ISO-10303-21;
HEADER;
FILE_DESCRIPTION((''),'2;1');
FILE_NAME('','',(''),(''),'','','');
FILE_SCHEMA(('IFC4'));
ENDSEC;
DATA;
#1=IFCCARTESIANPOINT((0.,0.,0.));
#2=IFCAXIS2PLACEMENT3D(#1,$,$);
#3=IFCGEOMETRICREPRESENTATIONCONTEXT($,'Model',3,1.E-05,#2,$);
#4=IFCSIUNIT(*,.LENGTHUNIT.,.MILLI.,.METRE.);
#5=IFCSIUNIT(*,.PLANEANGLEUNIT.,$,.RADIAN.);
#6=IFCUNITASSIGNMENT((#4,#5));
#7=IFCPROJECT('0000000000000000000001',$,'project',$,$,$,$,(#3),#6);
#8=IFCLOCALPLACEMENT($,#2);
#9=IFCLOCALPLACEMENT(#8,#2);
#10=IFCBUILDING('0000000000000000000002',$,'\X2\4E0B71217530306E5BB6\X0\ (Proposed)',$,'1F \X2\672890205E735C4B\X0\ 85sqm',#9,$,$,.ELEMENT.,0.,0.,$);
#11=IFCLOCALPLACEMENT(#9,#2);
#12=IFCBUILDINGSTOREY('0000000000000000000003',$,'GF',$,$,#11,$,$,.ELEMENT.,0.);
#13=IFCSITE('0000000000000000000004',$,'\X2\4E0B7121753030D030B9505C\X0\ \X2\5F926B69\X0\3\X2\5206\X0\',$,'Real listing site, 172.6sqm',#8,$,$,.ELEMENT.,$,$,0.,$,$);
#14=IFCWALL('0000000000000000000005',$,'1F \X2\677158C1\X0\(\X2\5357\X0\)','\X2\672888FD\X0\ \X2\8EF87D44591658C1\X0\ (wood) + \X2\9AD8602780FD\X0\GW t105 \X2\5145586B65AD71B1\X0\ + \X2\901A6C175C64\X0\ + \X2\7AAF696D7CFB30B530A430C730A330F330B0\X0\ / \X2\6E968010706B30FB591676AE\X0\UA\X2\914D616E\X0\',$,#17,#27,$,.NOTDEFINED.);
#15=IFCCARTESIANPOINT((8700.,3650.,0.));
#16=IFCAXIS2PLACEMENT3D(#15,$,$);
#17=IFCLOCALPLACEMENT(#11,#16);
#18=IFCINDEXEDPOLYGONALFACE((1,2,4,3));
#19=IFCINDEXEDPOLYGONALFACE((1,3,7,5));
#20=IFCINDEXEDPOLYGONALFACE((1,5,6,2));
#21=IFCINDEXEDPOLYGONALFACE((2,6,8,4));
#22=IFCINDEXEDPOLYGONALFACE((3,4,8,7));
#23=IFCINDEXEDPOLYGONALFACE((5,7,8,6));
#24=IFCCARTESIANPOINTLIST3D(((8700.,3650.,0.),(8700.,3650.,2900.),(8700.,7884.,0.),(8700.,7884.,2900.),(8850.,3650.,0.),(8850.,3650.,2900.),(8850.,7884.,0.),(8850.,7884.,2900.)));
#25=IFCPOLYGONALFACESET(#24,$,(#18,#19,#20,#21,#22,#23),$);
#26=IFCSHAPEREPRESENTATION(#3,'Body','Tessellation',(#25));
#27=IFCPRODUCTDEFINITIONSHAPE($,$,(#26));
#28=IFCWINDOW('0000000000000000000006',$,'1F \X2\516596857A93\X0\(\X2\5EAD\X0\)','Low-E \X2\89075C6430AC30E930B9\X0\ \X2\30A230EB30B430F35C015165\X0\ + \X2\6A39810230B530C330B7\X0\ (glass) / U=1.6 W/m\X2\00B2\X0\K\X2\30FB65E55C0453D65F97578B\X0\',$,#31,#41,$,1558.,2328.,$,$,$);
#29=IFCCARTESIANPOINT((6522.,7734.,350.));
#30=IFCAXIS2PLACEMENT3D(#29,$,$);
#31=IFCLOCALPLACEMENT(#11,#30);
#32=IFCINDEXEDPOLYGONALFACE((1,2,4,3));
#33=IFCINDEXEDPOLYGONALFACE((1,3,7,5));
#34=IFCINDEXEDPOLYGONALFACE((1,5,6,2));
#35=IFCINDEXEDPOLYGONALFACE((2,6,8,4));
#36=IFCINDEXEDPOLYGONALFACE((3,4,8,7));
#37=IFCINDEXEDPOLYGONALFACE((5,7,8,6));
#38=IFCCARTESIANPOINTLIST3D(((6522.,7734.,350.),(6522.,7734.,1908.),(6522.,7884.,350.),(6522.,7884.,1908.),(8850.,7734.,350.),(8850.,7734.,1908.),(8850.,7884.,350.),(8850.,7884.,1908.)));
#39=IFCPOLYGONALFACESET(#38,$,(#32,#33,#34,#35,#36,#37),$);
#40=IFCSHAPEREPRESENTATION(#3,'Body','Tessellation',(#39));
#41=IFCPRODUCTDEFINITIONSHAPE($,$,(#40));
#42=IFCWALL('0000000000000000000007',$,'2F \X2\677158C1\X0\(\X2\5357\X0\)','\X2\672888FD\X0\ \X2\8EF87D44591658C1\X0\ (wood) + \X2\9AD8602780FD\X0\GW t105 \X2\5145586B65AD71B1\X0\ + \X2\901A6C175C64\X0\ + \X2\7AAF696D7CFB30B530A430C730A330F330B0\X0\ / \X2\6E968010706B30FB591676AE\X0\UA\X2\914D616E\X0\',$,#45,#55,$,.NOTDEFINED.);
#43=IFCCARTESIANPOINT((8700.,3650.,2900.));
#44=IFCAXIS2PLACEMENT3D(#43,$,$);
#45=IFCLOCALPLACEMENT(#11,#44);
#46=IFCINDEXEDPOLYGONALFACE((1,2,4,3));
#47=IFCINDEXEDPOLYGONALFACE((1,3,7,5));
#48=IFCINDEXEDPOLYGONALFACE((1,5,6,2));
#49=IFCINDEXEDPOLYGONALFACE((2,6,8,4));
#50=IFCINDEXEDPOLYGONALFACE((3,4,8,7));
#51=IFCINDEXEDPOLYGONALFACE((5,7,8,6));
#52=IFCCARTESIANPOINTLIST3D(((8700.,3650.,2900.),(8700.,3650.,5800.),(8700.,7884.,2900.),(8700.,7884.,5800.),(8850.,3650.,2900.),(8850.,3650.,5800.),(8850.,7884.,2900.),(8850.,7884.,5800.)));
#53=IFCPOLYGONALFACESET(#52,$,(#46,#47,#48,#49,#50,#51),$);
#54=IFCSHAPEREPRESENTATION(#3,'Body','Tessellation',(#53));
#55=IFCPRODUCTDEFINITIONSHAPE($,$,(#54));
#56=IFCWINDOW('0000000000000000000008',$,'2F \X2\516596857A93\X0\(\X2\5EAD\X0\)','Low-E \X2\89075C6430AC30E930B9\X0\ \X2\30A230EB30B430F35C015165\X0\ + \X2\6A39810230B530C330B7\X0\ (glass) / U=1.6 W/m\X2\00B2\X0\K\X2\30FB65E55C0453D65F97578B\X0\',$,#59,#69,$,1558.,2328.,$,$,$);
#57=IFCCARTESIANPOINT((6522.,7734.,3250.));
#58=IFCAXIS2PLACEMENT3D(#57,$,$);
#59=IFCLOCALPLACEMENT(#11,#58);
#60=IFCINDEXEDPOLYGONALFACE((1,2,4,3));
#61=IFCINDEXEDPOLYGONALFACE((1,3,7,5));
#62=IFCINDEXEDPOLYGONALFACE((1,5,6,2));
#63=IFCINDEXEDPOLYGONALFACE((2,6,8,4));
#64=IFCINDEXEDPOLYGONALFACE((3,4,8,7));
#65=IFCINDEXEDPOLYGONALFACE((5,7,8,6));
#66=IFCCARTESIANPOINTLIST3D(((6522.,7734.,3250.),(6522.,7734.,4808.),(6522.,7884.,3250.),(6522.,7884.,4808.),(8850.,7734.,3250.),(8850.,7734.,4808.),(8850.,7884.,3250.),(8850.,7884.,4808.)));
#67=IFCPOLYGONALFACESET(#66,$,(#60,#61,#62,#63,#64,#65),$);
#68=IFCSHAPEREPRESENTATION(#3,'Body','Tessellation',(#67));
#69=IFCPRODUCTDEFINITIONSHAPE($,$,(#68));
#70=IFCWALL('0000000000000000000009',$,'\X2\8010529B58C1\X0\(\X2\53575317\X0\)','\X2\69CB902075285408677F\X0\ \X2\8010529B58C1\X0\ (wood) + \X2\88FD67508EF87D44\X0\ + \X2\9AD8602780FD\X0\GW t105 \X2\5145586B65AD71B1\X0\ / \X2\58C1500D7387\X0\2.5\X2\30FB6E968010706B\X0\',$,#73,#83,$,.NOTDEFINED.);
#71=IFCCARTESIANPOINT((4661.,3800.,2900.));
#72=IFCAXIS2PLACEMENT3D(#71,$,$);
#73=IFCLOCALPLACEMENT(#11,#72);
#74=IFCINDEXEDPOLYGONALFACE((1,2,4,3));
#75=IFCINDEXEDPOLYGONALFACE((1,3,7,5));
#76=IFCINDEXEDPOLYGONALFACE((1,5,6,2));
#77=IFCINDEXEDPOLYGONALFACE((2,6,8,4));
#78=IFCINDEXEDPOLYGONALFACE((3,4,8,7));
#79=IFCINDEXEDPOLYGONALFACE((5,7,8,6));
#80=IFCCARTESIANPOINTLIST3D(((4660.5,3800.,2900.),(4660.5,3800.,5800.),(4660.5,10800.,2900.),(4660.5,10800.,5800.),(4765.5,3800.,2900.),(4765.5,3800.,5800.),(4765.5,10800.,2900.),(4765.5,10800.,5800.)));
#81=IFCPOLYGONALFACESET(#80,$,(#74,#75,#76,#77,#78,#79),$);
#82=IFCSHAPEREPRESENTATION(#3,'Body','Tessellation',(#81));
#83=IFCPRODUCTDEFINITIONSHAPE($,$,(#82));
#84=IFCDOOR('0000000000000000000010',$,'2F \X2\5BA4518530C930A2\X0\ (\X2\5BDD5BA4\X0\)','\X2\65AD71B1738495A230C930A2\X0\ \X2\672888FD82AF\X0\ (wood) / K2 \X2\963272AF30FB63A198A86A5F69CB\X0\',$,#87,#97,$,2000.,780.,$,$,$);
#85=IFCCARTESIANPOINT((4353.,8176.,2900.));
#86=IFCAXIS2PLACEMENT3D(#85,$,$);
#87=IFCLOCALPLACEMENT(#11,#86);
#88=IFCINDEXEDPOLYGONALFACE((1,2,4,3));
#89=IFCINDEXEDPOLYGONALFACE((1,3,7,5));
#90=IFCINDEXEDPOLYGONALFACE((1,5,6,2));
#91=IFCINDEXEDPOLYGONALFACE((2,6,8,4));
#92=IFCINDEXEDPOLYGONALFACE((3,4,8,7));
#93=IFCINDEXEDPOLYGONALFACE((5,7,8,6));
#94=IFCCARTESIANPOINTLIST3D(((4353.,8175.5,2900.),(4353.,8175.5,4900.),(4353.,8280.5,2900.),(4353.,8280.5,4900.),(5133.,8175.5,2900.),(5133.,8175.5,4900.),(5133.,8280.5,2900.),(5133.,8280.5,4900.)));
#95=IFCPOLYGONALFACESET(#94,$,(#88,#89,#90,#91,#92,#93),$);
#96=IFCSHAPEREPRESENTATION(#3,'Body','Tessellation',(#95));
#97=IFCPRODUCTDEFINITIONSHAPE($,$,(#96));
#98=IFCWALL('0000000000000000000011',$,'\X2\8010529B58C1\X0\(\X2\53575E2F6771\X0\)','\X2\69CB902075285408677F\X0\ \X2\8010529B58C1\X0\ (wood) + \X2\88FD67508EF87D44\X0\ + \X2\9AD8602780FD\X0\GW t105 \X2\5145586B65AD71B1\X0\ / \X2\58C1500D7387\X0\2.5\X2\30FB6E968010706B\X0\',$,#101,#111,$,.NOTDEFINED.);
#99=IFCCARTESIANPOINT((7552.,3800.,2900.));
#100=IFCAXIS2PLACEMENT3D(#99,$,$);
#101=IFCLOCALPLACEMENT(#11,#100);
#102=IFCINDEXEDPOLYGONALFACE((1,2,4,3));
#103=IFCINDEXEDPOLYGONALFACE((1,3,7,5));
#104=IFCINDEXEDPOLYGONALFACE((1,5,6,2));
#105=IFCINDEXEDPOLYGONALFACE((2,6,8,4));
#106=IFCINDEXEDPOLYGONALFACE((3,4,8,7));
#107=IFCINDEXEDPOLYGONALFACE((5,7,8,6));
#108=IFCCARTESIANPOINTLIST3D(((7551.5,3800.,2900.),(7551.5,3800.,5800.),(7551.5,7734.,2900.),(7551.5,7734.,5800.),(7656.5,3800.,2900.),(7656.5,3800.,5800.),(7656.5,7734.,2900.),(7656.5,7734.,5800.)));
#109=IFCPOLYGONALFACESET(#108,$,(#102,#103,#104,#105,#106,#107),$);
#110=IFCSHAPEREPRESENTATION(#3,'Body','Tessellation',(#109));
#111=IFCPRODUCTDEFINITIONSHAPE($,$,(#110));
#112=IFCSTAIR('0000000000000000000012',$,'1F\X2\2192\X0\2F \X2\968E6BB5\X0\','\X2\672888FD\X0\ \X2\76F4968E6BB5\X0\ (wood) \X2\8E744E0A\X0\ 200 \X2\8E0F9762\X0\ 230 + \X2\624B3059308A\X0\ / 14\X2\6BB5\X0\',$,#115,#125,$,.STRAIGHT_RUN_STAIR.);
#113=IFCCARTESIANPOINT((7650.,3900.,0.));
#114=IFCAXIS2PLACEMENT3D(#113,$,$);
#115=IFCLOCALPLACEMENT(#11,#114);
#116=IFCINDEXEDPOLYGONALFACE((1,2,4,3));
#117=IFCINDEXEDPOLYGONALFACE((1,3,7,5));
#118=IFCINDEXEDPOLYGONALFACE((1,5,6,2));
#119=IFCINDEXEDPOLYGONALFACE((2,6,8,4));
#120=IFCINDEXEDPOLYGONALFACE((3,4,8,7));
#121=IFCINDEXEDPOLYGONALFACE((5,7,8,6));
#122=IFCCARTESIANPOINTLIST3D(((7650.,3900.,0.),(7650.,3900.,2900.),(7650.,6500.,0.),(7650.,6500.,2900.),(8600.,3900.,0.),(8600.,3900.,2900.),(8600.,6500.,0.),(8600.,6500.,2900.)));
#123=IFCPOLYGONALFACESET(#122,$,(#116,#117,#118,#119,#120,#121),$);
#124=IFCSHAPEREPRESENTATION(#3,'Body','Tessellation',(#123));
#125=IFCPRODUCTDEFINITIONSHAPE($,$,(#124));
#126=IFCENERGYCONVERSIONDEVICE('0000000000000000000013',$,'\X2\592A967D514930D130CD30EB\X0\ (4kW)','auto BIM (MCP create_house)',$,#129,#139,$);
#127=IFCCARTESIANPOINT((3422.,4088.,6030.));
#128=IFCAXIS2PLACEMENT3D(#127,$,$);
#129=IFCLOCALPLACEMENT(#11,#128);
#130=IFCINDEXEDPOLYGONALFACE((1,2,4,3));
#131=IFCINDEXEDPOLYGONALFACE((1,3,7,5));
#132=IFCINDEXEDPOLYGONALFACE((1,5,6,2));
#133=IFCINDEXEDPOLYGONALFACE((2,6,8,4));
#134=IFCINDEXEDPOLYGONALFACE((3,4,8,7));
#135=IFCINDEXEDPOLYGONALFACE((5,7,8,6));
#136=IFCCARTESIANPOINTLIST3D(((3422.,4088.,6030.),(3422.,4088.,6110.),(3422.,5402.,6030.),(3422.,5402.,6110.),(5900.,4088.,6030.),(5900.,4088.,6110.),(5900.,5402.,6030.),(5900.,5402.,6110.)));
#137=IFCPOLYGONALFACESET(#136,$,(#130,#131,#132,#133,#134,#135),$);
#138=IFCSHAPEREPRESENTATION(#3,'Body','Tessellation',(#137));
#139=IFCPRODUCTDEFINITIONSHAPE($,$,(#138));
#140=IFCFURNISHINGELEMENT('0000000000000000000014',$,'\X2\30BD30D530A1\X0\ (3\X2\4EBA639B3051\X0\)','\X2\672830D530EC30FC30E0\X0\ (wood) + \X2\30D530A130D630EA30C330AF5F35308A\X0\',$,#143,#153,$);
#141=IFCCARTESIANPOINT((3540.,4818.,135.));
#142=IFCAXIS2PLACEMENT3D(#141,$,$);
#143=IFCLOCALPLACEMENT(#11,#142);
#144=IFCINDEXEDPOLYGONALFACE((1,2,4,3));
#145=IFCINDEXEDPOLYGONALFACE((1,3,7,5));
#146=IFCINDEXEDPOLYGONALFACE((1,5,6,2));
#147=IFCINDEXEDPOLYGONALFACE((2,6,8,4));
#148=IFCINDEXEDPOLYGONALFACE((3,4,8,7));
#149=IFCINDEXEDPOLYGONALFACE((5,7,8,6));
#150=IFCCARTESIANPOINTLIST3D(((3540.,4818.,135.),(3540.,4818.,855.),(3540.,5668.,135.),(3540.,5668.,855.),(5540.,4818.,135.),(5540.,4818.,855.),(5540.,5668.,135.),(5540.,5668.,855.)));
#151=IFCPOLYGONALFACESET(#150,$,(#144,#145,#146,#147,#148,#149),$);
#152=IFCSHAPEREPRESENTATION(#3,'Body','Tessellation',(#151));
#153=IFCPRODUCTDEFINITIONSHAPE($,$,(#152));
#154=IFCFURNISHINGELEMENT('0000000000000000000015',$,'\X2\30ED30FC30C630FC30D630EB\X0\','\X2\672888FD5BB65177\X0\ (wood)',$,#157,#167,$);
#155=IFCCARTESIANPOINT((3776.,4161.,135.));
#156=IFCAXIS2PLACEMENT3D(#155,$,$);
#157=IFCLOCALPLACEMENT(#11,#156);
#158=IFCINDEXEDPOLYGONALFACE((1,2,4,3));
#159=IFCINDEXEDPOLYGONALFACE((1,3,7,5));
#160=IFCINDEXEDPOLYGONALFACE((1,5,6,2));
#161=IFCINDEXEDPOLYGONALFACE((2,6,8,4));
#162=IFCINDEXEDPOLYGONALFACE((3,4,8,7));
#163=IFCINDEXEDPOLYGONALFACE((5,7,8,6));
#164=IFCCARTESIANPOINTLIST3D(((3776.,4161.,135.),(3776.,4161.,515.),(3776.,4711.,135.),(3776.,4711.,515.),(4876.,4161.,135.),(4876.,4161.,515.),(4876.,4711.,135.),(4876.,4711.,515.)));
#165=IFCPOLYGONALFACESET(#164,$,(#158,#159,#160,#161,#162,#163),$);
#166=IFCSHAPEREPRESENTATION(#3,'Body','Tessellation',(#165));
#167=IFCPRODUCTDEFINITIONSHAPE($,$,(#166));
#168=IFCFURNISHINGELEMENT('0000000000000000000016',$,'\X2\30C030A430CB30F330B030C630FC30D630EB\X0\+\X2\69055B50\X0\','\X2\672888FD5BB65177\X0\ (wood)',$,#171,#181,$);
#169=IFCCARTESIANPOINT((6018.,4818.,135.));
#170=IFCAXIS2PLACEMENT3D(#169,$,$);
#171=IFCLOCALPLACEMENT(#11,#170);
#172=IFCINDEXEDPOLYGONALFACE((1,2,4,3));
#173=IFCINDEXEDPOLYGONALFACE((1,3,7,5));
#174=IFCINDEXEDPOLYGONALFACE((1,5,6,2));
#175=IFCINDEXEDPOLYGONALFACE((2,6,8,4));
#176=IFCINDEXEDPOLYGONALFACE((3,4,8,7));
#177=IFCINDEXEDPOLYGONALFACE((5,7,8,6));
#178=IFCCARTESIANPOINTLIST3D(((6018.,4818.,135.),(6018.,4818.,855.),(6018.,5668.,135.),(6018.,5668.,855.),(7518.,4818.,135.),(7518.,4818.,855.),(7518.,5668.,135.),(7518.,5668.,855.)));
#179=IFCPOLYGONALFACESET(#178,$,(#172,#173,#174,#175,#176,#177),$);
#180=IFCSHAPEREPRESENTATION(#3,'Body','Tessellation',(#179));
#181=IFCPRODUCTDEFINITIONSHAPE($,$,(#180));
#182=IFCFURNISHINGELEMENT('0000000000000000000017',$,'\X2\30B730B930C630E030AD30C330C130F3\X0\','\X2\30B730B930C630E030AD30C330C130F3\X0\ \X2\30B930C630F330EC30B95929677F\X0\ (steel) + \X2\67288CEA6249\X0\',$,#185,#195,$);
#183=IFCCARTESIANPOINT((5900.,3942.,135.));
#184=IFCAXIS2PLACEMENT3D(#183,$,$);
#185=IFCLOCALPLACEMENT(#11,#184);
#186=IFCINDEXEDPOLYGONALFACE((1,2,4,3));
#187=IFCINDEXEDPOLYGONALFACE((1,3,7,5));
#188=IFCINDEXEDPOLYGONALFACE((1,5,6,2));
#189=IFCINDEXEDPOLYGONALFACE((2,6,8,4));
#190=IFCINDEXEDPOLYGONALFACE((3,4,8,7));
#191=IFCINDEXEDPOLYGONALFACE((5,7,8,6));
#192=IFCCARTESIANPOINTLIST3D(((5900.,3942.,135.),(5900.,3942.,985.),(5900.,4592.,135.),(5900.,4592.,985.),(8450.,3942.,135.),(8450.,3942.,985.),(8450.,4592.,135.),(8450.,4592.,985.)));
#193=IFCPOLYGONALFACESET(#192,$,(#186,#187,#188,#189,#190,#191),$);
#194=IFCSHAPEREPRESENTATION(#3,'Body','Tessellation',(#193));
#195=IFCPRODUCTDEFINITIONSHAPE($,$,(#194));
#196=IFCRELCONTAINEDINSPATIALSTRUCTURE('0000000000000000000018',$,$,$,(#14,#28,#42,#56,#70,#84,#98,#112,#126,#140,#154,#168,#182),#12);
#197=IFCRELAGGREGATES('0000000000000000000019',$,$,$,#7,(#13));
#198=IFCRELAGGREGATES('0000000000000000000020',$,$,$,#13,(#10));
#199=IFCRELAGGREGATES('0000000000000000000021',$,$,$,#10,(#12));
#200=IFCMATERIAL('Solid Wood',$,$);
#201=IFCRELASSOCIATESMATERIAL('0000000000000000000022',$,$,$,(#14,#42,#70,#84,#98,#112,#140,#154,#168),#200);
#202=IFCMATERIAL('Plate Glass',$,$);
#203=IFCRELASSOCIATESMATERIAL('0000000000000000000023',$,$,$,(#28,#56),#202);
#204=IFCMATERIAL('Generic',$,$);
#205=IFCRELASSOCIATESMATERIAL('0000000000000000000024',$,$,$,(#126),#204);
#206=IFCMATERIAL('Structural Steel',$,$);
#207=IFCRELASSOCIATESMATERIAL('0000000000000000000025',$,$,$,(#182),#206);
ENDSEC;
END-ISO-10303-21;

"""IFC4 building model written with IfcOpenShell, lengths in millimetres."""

from ifc_helpers import new_model, si_unit, frame, frame_2d, origin, place, context, project, spatial, rectangle, extrude, material, element, fill, save


model = new_model("IFC4")

# Units and contexts
model_context = context("Model", 3, precision=1e-05, world=origin())
ifc_project = project(units=[si_unit("LENGTHUNIT", "METRE", prefix="MILLI"), si_unit("PLANEANGLEUNIT", "RADIAN")], contexts=[model_context])

# Site, building, storey
site_placement = place(None, origin())
site = spatial("IfcSite", under=ifc_project, at=site_placement, Name="下無田バス停 徒歩3分", ObjectType="Real listing site, 172.6sqm", CompositionType="ELEMENT", RefElevation=0.0)
building_placement = place(site_placement, origin())
building = spatial("IfcBuilding", under=site, at=building_placement, Name="下無田の家 (Proposed)", ObjectType="1F 木造平屋 85sqm", CompositionType="ELEMENT", ElevationOfRefHeight=0.0, ElevationOfTerrain=0.0)
storey_placement = place(building_placement, origin())
storey = spatial("IfcBuildingStorey", under=building, at=storey_placement, Name="GF", CompositionType="ELEMENT", Elevation=0.0)

# Wall, opening, window
ifc_material_1 = material(Name="Solid Wood")
wall_1_placement = place(storey_placement, frame((8700.0, 3650.0, 0.0)))
wall_1 = element("IfcWall", 1, at=wall_1_placement, inside=storey, material=ifc_material_1, Name="1F 東壁(南)", Description="木製 軸組外壁 (wood) + 高性能GW t105 充填断熱 + 通気層 + 窯業系サイディング / 準耐火・外皮UA配慮", PredefinedType="NOTDEFINED", context=model_context, shape_type="SweptSolid", body=[
    extrude(rectangle(XDim=150.0, YDim=4234.0, at=frame_2d((75.0, 2117.0))), frame((8700.0, 3650.0, 0.0)), (0.0, 0.0, 1.0), 2900.0),
])
opening_1_placement = place(storey_placement, frame((6522.0, 7734.0, 350.0)))
opening_1 = element("IfcOpeningElement", 2, at=opening_1_placement, cuts=wall_1, PredefinedType="NOTDEFINED", context=model_context, shape_type="SweptSolid", body=[
    extrude(rectangle(XDim=2328.0, YDim=150.0, at=frame_2d((1164.0, 75.0))), frame((6522.0, 7734.0, 350.0)), (0.0, 0.0, 1.0), 1558.0),
])
ifc_material_2 = material(Name="Plate Glass")
window_1_placement = place(storey_placement, frame((6522.0, 7734.0, 350.0)))
window_1 = element("IfcWindow", 3, at=window_1_placement, inside=storey, material=ifc_material_2, Name="1F 入隅窓(庭)", Description="Low-E 複層ガラス アルゴン封入 + 樹脂サッシ (glass) / U=1.6 W/m²K・日射取得型", OverallHeight=1558.0, OverallWidth=2328.0, context=model_context, shape_type="SweptSolid", body=[
    extrude(rectangle(XDim=2328.0, YDim=150.0, at=frame_2d((1164.0, 75.0))), frame((6522.0, 7734.0, 350.0)), (0.0, 0.0, 1.0), 1558.0),
])
fill(opening_1, window_1)

# Wall, opening, window
wall_2_placement = place(storey_placement, frame((8700.0, 3650.0, 2900.0)))
wall_2 = element("IfcWall", 4, at=wall_2_placement, inside=storey, material=ifc_material_1, Name="2F 東壁(南)", Description="木製 軸組外壁 (wood) + 高性能GW t105 充填断熱 + 通気層 + 窯業系サイディング / 準耐火・外皮UA配慮", PredefinedType="NOTDEFINED", context=model_context, shape_type="SweptSolid", body=[
    extrude(rectangle(XDim=150.0, YDim=4234.0, at=frame_2d((75.0, 2117.0))), frame((8700.0, 3650.0, 2900.0)), (0.0, 0.0, 1.0), 2900.0),
])
opening_2_placement = place(storey_placement, frame((6522.0, 7734.0, 3250.0)))
opening_2 = element("IfcOpeningElement", 5, at=opening_2_placement, cuts=wall_2, PredefinedType="NOTDEFINED", context=model_context, shape_type="SweptSolid", body=[
    extrude(rectangle(XDim=2328.0, YDim=150.0, at=frame_2d((1164.0, 75.0))), frame((6522.0, 7734.0, 3250.0)), (0.0, 0.0, 1.0), 1558.0),
])
window_2_placement = place(storey_placement, frame((6522.0, 7734.0, 3250.0)))
window_2 = element("IfcWindow", 6, at=window_2_placement, inside=storey, material=ifc_material_2, Name="2F 入隅窓(庭)", Description="Low-E 複層ガラス アルゴン封入 + 樹脂サッシ (glass) / U=1.6 W/m²K・日射取得型", OverallHeight=1558.0, OverallWidth=2328.0, context=model_context, shape_type="SweptSolid", body=[
    extrude(rectangle(XDim=2328.0, YDim=150.0, at=frame_2d((1164.0, 75.0))), frame((6522.0, 7734.0, 3250.0)), (0.0, 0.0, 1.0), 1558.0),
])
fill(opening_2, window_2)

# Wall, opening, door
wall_3_placement = place(storey_placement, frame((4661.0, 3800.0, 2900.0)))
wall_3 = element("IfcWall", 7, at=wall_3_placement, inside=storey, material=ifc_material_1, Name="耐力壁(南北)", Description="構造用合板 耐力壁 (wood) + 製材軸組 + 高性能GW t105 充填断熱 / 壁倍率2.5・準耐火", PredefinedType="NOTDEFINED", context=model_context, shape_type="SweptSolid", body=[
    extrude(rectangle(XDim=105.0, YDim=7000.0, at=frame_2d((52.0, 3500.0))), frame((4661.0, 3800.0, 2900.0)), (0.0, 0.0, 1.0), 2900.0),
])
opening_3_placement = place(storey_placement, frame((4353.0, 8176.0, 2900.0)))
opening_3 = element("IfcOpeningElement", 8, at=opening_3_placement, cuts=wall_3, PredefinedType="NOTDEFINED", context=model_context, shape_type="SweptSolid", body=[
    extrude(rectangle(XDim=780.0, YDim=105.0, at=frame_2d((390.0, 52.0))), frame((4353.0, 8176.0, 2900.0)), (0.0, 0.0, 1.0), 2000.0),
])
door_1_placement = place(storey_placement, frame((4353.0, 8176.0, 2900.0)))
door_1 = element("IfcDoor", 9, at=door_1_placement, inside=storey, material=ifc_material_1, Name="2F 室内ドア (寝室)", Description="断熱玄関ドア 木製芯 (wood) / K2 防犯・採風機構", OverallHeight=2000.0, OverallWidth=780.0, context=model_context, shape_type="SweptSolid", body=[
    extrude(rectangle(XDim=780.0, YDim=105.0, at=frame_2d((390.0, 52.0))), frame((4353.0, 8176.0, 2900.0)), (0.0, 0.0, 1.0), 2000.0),
])
fill(opening_3, door_1)

# Wall
wall_4_placement = place(storey_placement, frame((7552.0, 3800.0, 2900.0)))
element("IfcWall", 10, at=wall_4_placement, inside=storey, material=ifc_material_1, Name="耐力壁(南帯東)", Description="構造用合板 耐力壁 (wood) + 製材軸組 + 高性能GW t105 充填断熱 / 壁倍率2.5・準耐火", PredefinedType="NOTDEFINED", context=model_context, shape_type="SweptSolid", body=[
    extrude(rectangle(XDim=105.0, YDim=3934.0, at=frame_2d((52.0, 1967.0))), frame((7552.0, 3800.0, 2900.0)), (0.0, 0.0, 1.0), 2900.0),
])

# Stair
stair_placement = place(storey_placement, frame((7650.0, 3900.0, 0.0)))
element("IfcStair", 11, at=stair_placement, inside=storey, material=ifc_material_1, Name="1F→2F 階段", Description="木製 直階段 (wood) 蹴上 200 踏面 230 + 手すり / 14段", PredefinedType="STRAIGHT_RUN_STAIR", context=model_context, shape_type="SweptSolid", body=[
    extrude(rectangle(XDim=950.0, YDim=2600.0, at=frame_2d((475.0, 1300.0))), frame((7650.0, 3900.0, 0.0)), (0.0, 0.0, 1.0), 2900.0),
])

# Energy conversion device
ifc_material_3 = material(Name="Generic")
energy_conversion_device_placement = place(storey_placement, frame((3422.0, 4088.0, 6030.0)))
element("IfcEnergyConversionDevice", 12, at=energy_conversion_device_placement, inside=storey, material=ifc_material_3, Name="太陽光パネル (4kW)", Description="auto BIM (MCP create_house)", context=model_context, shape_type="SweptSolid", body=[
    extrude(rectangle(XDim=2478.0, YDim=1314.0, at=frame_2d((1239.0, 657.0))), frame((3422.0, 4088.0, 6030.0)), (0.0, 0.0, 1.0), 80.0),
])

# Furnishing elements
furnishing_1_placement = place(storey_placement, frame((3540.0, 4818.0, 135.0)))
element("IfcFurnishingElement", 13, at=furnishing_1_placement, inside=storey, material=ifc_material_1, Name="ソファ (3人掛け)", Description="木フレーム (wood) + ファブリック張り", context=model_context, shape_type="SweptSolid", body=[
    extrude(rectangle(XDim=2000.0, YDim=850.0, at=frame_2d((1000.0, 425.0))), frame((3540.0, 4818.0, 135.0)), (0.0, 0.0, 1.0), 720.0),
])
furnishing_2_placement = place(storey_placement, frame((3776.0, 4161.0, 135.0)))
element("IfcFurnishingElement", 14, at=furnishing_2_placement, inside=storey, material=ifc_material_1, Name="ローテーブル", Description="木製家具 (wood)", context=model_context, shape_type="SweptSolid", body=[
    extrude(rectangle(XDim=1100.0, YDim=550.0, at=frame_2d((550.0, 275.0))), frame((3776.0, 4161.0, 135.0)), (0.0, 0.0, 1.0), 380.0),
])
furnishing_3_placement = place(storey_placement, frame((6018.0, 4818.0, 135.0)))
element("IfcFurnishingElement", 15, at=furnishing_3_placement, inside=storey, material=ifc_material_1, Name="ダイニングテーブル+椅子", Description="木製家具 (wood)", context=model_context, shape_type="SweptSolid", body=[
    extrude(rectangle(XDim=1500.0, YDim=850.0, at=frame_2d((750.0, 425.0))), frame((6018.0, 4818.0, 135.0)), (0.0, 0.0, 1.0), 720.0),
])
ifc_material_4 = material(Name="Structural Steel")
furnishing_4_placement = place(storey_placement, frame((5900.0, 3942.0, 135.0)))
element("IfcFurnishingElement", 16, at=furnishing_4_placement, inside=storey, material=ifc_material_4, Name="システムキッチン", Description="システムキッチン ステンレス天板 (steel) + 木質扉", context=model_context, shape_type="SweptSolid", body=[
    extrude(rectangle(XDim=2550.0, YDim=650.0, at=frame_2d((1275.0, 325.0))), frame((5900.0, 3942.0, 135.0)), (0.0, 0.0, 1.0), 850.0),
])

save(model, "model.ifc")
